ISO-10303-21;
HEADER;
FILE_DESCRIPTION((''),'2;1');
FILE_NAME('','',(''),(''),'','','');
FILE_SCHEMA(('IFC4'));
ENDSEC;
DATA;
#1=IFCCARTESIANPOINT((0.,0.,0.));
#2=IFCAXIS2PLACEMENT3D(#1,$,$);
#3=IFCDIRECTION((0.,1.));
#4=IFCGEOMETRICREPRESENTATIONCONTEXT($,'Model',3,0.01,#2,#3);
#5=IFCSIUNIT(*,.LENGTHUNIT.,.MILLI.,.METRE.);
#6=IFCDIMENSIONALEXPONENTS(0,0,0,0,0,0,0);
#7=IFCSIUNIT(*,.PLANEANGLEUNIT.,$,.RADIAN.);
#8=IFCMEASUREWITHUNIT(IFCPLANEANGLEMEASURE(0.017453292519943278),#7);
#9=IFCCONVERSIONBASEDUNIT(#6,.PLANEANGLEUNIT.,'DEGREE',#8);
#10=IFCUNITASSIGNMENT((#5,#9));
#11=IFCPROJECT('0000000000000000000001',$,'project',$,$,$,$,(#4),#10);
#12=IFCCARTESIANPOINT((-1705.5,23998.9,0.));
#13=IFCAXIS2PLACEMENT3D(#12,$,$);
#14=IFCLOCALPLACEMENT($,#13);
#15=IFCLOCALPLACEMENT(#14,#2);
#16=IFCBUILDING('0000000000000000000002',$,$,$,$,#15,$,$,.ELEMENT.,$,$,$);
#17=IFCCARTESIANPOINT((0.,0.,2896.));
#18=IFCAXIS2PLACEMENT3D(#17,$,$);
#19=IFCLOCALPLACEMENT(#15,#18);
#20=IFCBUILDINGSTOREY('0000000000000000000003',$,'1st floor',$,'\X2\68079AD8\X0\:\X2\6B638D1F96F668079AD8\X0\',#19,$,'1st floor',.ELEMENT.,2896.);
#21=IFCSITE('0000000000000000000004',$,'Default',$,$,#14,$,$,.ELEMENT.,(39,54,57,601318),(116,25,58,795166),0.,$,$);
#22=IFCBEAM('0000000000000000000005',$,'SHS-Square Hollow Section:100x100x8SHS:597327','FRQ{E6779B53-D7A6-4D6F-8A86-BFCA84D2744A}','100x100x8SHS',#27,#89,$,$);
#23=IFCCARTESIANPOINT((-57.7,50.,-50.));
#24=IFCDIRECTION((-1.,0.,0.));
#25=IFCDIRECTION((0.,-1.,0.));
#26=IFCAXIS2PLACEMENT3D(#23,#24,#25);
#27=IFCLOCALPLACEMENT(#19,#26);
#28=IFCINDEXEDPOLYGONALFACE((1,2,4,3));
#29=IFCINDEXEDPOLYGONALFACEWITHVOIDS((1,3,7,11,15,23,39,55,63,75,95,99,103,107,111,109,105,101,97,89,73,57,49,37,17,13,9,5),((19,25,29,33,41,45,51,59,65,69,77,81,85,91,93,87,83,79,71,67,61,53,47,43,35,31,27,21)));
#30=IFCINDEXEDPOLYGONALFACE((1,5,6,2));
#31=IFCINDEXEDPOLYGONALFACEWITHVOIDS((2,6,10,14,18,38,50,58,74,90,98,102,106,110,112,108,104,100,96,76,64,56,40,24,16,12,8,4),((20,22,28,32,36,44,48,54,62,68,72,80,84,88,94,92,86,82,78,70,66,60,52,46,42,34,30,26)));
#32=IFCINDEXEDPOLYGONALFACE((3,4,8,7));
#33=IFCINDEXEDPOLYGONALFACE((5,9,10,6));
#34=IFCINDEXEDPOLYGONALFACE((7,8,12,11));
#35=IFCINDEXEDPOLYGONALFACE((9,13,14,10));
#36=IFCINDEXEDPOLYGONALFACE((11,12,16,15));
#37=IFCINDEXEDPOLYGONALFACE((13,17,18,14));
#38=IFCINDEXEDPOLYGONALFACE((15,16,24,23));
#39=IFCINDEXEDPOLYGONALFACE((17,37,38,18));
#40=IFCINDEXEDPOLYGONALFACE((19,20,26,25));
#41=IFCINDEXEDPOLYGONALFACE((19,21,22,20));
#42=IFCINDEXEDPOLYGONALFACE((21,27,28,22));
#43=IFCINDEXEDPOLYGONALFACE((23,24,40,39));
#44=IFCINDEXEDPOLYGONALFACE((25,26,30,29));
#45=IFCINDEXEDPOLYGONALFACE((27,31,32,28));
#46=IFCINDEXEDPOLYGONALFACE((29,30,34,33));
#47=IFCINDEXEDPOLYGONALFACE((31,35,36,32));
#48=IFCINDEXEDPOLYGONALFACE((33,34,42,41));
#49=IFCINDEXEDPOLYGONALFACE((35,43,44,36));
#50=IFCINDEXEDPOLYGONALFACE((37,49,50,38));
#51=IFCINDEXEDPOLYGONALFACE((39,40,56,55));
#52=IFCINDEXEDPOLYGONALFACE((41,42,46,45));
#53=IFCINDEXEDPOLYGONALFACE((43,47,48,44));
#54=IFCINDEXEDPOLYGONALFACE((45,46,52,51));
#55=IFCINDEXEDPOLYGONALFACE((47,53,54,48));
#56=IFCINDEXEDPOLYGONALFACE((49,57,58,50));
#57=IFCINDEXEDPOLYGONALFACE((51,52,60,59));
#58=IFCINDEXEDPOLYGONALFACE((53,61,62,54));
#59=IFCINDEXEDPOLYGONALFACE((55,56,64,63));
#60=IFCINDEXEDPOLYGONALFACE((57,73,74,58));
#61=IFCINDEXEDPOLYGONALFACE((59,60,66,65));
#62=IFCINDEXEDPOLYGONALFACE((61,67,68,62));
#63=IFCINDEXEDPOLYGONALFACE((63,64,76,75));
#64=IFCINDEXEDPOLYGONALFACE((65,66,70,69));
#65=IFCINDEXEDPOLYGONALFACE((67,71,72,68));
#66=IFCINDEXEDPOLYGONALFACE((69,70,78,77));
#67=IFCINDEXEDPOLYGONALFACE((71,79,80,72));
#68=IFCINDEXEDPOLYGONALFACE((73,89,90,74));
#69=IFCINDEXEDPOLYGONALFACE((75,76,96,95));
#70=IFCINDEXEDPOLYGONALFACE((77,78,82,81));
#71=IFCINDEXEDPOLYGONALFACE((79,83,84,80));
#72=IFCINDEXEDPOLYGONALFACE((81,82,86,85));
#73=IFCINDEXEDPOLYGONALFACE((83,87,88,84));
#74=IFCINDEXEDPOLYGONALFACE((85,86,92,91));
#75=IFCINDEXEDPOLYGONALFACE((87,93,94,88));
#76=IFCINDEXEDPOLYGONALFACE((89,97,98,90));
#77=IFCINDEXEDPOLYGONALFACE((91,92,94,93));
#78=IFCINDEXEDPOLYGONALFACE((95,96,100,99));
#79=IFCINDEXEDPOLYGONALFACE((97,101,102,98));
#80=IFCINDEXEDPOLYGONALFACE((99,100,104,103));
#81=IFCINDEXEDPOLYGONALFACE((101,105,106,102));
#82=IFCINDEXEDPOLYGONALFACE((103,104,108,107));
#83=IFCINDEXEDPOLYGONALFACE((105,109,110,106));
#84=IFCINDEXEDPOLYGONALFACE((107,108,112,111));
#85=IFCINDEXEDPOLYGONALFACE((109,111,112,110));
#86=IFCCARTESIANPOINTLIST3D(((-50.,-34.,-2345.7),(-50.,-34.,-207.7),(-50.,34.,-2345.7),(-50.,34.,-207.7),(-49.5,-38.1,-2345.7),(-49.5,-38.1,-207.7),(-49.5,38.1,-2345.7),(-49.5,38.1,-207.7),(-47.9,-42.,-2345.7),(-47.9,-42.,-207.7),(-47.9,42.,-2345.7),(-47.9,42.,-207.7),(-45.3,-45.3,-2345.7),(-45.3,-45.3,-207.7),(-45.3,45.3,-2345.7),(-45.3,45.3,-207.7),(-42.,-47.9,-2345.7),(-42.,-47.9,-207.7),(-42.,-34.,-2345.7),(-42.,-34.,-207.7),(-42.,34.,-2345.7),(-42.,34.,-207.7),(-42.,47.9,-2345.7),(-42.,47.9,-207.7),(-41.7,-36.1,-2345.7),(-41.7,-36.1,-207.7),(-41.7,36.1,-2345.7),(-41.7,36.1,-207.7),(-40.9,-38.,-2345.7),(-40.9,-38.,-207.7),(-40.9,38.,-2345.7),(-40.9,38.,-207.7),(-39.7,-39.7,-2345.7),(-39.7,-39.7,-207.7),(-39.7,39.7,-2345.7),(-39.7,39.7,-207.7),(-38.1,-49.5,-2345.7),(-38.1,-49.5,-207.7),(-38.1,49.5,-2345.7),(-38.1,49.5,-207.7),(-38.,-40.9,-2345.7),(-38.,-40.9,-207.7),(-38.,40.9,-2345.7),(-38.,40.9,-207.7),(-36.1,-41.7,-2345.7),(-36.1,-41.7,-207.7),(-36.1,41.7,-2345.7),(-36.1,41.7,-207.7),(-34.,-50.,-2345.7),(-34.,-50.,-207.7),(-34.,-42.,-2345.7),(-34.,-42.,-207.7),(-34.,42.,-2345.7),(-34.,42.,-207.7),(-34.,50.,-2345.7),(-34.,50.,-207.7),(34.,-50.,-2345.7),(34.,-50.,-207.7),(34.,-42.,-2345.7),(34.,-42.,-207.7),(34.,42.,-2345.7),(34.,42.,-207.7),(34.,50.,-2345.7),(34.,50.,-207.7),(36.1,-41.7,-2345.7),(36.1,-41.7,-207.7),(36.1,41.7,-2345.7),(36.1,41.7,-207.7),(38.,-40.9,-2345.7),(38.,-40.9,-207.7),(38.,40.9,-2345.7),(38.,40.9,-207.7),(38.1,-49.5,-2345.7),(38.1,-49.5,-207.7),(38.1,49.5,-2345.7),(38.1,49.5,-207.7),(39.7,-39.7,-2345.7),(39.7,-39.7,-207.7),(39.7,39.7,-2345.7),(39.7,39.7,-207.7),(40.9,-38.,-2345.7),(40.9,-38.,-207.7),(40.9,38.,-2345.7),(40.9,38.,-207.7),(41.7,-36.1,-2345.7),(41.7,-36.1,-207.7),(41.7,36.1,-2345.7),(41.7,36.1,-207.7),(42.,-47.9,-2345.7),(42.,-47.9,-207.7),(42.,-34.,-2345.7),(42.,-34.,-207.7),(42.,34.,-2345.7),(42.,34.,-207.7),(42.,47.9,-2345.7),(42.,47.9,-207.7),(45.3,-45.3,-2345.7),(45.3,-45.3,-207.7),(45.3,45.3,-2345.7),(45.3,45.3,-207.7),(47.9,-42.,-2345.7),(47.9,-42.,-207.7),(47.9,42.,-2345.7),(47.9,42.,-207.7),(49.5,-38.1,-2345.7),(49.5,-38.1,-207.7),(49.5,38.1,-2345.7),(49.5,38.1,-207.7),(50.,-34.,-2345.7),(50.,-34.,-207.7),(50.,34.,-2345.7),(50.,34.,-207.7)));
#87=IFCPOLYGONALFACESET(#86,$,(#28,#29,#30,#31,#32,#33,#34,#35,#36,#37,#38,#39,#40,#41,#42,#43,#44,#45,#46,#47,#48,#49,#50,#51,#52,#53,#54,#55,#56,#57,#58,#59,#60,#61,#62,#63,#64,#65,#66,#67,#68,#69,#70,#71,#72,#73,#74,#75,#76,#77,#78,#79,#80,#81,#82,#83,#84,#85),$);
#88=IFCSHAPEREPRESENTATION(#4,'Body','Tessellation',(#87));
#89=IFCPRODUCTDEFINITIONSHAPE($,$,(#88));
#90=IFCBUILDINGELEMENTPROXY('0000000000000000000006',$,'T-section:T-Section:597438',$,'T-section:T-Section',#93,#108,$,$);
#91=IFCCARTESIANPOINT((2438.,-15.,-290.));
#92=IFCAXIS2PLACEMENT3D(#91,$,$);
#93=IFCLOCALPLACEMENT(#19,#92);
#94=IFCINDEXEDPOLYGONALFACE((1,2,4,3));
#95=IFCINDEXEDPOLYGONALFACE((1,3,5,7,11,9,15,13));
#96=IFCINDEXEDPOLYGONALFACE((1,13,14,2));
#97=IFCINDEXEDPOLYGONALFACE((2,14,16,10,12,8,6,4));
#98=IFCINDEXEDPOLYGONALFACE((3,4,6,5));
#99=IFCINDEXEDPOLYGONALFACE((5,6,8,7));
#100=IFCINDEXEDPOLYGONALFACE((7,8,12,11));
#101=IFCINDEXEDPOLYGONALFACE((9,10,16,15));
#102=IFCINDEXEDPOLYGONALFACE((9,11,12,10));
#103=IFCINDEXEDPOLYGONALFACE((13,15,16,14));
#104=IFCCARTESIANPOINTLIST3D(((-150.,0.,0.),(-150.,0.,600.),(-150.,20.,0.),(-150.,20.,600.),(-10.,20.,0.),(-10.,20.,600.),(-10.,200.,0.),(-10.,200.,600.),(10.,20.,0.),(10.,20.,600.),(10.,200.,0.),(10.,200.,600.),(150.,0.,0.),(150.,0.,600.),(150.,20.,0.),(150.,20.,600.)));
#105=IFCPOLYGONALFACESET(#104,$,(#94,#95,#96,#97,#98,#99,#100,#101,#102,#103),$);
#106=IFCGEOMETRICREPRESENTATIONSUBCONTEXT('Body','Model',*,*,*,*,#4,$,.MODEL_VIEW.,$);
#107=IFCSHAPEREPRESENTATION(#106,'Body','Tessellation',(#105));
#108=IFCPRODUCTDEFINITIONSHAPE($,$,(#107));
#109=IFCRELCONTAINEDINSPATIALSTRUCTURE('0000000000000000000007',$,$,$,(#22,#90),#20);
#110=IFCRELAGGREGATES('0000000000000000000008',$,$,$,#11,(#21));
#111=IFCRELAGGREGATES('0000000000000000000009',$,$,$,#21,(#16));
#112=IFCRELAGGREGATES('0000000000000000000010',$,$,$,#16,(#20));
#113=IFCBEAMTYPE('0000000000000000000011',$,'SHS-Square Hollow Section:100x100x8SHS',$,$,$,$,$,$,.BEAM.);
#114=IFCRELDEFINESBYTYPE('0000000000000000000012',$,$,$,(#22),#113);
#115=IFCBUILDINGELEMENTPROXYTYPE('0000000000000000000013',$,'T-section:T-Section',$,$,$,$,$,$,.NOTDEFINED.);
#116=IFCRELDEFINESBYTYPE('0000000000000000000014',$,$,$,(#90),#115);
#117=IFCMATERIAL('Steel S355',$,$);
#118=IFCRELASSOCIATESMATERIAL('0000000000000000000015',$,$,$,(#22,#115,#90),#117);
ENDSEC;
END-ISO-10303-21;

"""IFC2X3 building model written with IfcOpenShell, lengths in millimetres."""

from ifc_helpers import new_model, entity, si_unit, converted_unit, direction, frame, origin, origin_2d, place, context, subcontext, project, spatial, polyline, hollow_rectangle, outline, extrude, clip, halfspace, source, transform, mapped, material, type_object, type_shapes, element, save


model = new_model("IFC2X3")

# Units and contexts
model_context = context("Model", 3, precision=0.01, world=origin(), true_north=direction((0.0, 1.0)))
body_context = subcontext(model_context, "Body", "Model", "MODEL_VIEW")
ifc_project = project(units=[si_unit("LENGTHUNIT", "METRE", prefix="MILLI"), converted_unit("PLANEANGLEUNIT", "DEGREE", entity("IfcPlaneAngleMeasure", 0.017453292519943278), si_unit("PLANEANGLEUNIT", "RADIAN"), dimensions=[0, 0, 0, 0, 0, 0, 0])], contexts=[model_context])

# Site, building, storey
site_placement = place(None, frame((-1705.5, 23998.9, 0.0)))
site = spatial("IfcSite", under=ifc_project, at=site_placement, Name="Default", CompositionType="ELEMENT", RefLatitude=(39, 54, 57, 601318), RefLongitude=(116, 25, 58, 795166), RefElevation=0.0)
building_placement = place(site_placement, origin())
building = spatial("IfcBuilding", under=site, at=building_placement, CompositionType="ELEMENT")
storey_placement = place(building_placement, frame((0.0, 0.0, 2896.0)))
storey = spatial("IfcBuildingStorey", under=building, at=storey_placement, Name="1st floor", ObjectType="标高:正负零标高", LongName="1st floor", CompositionType="ELEMENT", Elevation=2896.0)

# Shared definitions
ifc_material_1 = material(Name="Steel S355")

# Beam
beam_type_1 = type_object("IfcBeamType", Name="SHS-Square Hollow Section:100x100x8SHS", PredefinedType="BEAM")
beam_1_placement = place(storey_placement, frame((-57.7, 50.0, -50.0), z_axis=(-1.0, 0.0, 0.0), x_axis=(0.0, -1.0, 0.0)))
element("IfcBeam", 1, at=beam_1_placement, inside=storey, type_object=beam_type_1, material=ifc_material_1, Name="SHS-Square Hollow Section:100x100x8SHS:597327", Description="FRQ{E6779B53-D7A6-4D6F-8A86-BFCA84D2744A}", ObjectType="100x100x8SHS", context=model_context, shape_type="Clipping", body=[
    clip(clip(extrude(hollow_rectangle(XDim=100.0, YDim=100.0, WallThickness=8.0, InnerFilletRadius=8.0, OuterFilletRadius=16.0, at=origin_2d()), origin(), (0.0, 0.0, -1.0), 2551.4), halfspace(frame((50.0, -2846.0, -207.7), z_axis=(0.0, 0.0, -1.0), x_axis=(-1.0, 0.0, 0.0)), True)), halfspace(frame((50.0, -2846.0, -2345.7), z_axis=(0.0, 0.0, 1.0), x_axis=(1.0, 0.0, 0.0)), True)),
])

# Building element proxy
building_element_proxy_type_1 = type_object("IfcBuildingElementProxyType", Name="T-section:T-Section", PredefinedType="NOTDEFINED", material=ifc_material_1)
shared_shape_1 = source(origin(), body_context, "Body", "SweptSolid", [
    extrude(outline(polyline([(-140.0, 10.0), (-140.0, -10.0), (40.0, -10.0), (40.0, -150.0), (60.0, -150.0), (60.0, 150.0), (40.0, 150.0), (40.0, 10.0), (-140.0, 10.0)])), frame((0.0, 60.0, 0.0), z_axis=(0.0, 0.0, -1.0), x_axis=(0.0, -1.0, 0.0)), (0.0, 0.0, -1.0), 600.0),
])
type_shapes(building_element_proxy_type_1, [shared_shape_1])
proxy_placement = place(storey_placement, frame((2438.0, -15.0, -290.0)))
element("IfcBuildingElementProxy", 2, at=proxy_placement, inside=storey, type_object=building_element_proxy_type_1, material=ifc_material_1, Name="T-section:T-Section:597438", ObjectType="T-section:T-Section", context=body_context, shape_type="MappedRepresentation", body=[
    mapped(shared_shape_1, transform((0.0, 0.0, 0.0), scale=1.0)),
])

save(model, "model.ifc")
